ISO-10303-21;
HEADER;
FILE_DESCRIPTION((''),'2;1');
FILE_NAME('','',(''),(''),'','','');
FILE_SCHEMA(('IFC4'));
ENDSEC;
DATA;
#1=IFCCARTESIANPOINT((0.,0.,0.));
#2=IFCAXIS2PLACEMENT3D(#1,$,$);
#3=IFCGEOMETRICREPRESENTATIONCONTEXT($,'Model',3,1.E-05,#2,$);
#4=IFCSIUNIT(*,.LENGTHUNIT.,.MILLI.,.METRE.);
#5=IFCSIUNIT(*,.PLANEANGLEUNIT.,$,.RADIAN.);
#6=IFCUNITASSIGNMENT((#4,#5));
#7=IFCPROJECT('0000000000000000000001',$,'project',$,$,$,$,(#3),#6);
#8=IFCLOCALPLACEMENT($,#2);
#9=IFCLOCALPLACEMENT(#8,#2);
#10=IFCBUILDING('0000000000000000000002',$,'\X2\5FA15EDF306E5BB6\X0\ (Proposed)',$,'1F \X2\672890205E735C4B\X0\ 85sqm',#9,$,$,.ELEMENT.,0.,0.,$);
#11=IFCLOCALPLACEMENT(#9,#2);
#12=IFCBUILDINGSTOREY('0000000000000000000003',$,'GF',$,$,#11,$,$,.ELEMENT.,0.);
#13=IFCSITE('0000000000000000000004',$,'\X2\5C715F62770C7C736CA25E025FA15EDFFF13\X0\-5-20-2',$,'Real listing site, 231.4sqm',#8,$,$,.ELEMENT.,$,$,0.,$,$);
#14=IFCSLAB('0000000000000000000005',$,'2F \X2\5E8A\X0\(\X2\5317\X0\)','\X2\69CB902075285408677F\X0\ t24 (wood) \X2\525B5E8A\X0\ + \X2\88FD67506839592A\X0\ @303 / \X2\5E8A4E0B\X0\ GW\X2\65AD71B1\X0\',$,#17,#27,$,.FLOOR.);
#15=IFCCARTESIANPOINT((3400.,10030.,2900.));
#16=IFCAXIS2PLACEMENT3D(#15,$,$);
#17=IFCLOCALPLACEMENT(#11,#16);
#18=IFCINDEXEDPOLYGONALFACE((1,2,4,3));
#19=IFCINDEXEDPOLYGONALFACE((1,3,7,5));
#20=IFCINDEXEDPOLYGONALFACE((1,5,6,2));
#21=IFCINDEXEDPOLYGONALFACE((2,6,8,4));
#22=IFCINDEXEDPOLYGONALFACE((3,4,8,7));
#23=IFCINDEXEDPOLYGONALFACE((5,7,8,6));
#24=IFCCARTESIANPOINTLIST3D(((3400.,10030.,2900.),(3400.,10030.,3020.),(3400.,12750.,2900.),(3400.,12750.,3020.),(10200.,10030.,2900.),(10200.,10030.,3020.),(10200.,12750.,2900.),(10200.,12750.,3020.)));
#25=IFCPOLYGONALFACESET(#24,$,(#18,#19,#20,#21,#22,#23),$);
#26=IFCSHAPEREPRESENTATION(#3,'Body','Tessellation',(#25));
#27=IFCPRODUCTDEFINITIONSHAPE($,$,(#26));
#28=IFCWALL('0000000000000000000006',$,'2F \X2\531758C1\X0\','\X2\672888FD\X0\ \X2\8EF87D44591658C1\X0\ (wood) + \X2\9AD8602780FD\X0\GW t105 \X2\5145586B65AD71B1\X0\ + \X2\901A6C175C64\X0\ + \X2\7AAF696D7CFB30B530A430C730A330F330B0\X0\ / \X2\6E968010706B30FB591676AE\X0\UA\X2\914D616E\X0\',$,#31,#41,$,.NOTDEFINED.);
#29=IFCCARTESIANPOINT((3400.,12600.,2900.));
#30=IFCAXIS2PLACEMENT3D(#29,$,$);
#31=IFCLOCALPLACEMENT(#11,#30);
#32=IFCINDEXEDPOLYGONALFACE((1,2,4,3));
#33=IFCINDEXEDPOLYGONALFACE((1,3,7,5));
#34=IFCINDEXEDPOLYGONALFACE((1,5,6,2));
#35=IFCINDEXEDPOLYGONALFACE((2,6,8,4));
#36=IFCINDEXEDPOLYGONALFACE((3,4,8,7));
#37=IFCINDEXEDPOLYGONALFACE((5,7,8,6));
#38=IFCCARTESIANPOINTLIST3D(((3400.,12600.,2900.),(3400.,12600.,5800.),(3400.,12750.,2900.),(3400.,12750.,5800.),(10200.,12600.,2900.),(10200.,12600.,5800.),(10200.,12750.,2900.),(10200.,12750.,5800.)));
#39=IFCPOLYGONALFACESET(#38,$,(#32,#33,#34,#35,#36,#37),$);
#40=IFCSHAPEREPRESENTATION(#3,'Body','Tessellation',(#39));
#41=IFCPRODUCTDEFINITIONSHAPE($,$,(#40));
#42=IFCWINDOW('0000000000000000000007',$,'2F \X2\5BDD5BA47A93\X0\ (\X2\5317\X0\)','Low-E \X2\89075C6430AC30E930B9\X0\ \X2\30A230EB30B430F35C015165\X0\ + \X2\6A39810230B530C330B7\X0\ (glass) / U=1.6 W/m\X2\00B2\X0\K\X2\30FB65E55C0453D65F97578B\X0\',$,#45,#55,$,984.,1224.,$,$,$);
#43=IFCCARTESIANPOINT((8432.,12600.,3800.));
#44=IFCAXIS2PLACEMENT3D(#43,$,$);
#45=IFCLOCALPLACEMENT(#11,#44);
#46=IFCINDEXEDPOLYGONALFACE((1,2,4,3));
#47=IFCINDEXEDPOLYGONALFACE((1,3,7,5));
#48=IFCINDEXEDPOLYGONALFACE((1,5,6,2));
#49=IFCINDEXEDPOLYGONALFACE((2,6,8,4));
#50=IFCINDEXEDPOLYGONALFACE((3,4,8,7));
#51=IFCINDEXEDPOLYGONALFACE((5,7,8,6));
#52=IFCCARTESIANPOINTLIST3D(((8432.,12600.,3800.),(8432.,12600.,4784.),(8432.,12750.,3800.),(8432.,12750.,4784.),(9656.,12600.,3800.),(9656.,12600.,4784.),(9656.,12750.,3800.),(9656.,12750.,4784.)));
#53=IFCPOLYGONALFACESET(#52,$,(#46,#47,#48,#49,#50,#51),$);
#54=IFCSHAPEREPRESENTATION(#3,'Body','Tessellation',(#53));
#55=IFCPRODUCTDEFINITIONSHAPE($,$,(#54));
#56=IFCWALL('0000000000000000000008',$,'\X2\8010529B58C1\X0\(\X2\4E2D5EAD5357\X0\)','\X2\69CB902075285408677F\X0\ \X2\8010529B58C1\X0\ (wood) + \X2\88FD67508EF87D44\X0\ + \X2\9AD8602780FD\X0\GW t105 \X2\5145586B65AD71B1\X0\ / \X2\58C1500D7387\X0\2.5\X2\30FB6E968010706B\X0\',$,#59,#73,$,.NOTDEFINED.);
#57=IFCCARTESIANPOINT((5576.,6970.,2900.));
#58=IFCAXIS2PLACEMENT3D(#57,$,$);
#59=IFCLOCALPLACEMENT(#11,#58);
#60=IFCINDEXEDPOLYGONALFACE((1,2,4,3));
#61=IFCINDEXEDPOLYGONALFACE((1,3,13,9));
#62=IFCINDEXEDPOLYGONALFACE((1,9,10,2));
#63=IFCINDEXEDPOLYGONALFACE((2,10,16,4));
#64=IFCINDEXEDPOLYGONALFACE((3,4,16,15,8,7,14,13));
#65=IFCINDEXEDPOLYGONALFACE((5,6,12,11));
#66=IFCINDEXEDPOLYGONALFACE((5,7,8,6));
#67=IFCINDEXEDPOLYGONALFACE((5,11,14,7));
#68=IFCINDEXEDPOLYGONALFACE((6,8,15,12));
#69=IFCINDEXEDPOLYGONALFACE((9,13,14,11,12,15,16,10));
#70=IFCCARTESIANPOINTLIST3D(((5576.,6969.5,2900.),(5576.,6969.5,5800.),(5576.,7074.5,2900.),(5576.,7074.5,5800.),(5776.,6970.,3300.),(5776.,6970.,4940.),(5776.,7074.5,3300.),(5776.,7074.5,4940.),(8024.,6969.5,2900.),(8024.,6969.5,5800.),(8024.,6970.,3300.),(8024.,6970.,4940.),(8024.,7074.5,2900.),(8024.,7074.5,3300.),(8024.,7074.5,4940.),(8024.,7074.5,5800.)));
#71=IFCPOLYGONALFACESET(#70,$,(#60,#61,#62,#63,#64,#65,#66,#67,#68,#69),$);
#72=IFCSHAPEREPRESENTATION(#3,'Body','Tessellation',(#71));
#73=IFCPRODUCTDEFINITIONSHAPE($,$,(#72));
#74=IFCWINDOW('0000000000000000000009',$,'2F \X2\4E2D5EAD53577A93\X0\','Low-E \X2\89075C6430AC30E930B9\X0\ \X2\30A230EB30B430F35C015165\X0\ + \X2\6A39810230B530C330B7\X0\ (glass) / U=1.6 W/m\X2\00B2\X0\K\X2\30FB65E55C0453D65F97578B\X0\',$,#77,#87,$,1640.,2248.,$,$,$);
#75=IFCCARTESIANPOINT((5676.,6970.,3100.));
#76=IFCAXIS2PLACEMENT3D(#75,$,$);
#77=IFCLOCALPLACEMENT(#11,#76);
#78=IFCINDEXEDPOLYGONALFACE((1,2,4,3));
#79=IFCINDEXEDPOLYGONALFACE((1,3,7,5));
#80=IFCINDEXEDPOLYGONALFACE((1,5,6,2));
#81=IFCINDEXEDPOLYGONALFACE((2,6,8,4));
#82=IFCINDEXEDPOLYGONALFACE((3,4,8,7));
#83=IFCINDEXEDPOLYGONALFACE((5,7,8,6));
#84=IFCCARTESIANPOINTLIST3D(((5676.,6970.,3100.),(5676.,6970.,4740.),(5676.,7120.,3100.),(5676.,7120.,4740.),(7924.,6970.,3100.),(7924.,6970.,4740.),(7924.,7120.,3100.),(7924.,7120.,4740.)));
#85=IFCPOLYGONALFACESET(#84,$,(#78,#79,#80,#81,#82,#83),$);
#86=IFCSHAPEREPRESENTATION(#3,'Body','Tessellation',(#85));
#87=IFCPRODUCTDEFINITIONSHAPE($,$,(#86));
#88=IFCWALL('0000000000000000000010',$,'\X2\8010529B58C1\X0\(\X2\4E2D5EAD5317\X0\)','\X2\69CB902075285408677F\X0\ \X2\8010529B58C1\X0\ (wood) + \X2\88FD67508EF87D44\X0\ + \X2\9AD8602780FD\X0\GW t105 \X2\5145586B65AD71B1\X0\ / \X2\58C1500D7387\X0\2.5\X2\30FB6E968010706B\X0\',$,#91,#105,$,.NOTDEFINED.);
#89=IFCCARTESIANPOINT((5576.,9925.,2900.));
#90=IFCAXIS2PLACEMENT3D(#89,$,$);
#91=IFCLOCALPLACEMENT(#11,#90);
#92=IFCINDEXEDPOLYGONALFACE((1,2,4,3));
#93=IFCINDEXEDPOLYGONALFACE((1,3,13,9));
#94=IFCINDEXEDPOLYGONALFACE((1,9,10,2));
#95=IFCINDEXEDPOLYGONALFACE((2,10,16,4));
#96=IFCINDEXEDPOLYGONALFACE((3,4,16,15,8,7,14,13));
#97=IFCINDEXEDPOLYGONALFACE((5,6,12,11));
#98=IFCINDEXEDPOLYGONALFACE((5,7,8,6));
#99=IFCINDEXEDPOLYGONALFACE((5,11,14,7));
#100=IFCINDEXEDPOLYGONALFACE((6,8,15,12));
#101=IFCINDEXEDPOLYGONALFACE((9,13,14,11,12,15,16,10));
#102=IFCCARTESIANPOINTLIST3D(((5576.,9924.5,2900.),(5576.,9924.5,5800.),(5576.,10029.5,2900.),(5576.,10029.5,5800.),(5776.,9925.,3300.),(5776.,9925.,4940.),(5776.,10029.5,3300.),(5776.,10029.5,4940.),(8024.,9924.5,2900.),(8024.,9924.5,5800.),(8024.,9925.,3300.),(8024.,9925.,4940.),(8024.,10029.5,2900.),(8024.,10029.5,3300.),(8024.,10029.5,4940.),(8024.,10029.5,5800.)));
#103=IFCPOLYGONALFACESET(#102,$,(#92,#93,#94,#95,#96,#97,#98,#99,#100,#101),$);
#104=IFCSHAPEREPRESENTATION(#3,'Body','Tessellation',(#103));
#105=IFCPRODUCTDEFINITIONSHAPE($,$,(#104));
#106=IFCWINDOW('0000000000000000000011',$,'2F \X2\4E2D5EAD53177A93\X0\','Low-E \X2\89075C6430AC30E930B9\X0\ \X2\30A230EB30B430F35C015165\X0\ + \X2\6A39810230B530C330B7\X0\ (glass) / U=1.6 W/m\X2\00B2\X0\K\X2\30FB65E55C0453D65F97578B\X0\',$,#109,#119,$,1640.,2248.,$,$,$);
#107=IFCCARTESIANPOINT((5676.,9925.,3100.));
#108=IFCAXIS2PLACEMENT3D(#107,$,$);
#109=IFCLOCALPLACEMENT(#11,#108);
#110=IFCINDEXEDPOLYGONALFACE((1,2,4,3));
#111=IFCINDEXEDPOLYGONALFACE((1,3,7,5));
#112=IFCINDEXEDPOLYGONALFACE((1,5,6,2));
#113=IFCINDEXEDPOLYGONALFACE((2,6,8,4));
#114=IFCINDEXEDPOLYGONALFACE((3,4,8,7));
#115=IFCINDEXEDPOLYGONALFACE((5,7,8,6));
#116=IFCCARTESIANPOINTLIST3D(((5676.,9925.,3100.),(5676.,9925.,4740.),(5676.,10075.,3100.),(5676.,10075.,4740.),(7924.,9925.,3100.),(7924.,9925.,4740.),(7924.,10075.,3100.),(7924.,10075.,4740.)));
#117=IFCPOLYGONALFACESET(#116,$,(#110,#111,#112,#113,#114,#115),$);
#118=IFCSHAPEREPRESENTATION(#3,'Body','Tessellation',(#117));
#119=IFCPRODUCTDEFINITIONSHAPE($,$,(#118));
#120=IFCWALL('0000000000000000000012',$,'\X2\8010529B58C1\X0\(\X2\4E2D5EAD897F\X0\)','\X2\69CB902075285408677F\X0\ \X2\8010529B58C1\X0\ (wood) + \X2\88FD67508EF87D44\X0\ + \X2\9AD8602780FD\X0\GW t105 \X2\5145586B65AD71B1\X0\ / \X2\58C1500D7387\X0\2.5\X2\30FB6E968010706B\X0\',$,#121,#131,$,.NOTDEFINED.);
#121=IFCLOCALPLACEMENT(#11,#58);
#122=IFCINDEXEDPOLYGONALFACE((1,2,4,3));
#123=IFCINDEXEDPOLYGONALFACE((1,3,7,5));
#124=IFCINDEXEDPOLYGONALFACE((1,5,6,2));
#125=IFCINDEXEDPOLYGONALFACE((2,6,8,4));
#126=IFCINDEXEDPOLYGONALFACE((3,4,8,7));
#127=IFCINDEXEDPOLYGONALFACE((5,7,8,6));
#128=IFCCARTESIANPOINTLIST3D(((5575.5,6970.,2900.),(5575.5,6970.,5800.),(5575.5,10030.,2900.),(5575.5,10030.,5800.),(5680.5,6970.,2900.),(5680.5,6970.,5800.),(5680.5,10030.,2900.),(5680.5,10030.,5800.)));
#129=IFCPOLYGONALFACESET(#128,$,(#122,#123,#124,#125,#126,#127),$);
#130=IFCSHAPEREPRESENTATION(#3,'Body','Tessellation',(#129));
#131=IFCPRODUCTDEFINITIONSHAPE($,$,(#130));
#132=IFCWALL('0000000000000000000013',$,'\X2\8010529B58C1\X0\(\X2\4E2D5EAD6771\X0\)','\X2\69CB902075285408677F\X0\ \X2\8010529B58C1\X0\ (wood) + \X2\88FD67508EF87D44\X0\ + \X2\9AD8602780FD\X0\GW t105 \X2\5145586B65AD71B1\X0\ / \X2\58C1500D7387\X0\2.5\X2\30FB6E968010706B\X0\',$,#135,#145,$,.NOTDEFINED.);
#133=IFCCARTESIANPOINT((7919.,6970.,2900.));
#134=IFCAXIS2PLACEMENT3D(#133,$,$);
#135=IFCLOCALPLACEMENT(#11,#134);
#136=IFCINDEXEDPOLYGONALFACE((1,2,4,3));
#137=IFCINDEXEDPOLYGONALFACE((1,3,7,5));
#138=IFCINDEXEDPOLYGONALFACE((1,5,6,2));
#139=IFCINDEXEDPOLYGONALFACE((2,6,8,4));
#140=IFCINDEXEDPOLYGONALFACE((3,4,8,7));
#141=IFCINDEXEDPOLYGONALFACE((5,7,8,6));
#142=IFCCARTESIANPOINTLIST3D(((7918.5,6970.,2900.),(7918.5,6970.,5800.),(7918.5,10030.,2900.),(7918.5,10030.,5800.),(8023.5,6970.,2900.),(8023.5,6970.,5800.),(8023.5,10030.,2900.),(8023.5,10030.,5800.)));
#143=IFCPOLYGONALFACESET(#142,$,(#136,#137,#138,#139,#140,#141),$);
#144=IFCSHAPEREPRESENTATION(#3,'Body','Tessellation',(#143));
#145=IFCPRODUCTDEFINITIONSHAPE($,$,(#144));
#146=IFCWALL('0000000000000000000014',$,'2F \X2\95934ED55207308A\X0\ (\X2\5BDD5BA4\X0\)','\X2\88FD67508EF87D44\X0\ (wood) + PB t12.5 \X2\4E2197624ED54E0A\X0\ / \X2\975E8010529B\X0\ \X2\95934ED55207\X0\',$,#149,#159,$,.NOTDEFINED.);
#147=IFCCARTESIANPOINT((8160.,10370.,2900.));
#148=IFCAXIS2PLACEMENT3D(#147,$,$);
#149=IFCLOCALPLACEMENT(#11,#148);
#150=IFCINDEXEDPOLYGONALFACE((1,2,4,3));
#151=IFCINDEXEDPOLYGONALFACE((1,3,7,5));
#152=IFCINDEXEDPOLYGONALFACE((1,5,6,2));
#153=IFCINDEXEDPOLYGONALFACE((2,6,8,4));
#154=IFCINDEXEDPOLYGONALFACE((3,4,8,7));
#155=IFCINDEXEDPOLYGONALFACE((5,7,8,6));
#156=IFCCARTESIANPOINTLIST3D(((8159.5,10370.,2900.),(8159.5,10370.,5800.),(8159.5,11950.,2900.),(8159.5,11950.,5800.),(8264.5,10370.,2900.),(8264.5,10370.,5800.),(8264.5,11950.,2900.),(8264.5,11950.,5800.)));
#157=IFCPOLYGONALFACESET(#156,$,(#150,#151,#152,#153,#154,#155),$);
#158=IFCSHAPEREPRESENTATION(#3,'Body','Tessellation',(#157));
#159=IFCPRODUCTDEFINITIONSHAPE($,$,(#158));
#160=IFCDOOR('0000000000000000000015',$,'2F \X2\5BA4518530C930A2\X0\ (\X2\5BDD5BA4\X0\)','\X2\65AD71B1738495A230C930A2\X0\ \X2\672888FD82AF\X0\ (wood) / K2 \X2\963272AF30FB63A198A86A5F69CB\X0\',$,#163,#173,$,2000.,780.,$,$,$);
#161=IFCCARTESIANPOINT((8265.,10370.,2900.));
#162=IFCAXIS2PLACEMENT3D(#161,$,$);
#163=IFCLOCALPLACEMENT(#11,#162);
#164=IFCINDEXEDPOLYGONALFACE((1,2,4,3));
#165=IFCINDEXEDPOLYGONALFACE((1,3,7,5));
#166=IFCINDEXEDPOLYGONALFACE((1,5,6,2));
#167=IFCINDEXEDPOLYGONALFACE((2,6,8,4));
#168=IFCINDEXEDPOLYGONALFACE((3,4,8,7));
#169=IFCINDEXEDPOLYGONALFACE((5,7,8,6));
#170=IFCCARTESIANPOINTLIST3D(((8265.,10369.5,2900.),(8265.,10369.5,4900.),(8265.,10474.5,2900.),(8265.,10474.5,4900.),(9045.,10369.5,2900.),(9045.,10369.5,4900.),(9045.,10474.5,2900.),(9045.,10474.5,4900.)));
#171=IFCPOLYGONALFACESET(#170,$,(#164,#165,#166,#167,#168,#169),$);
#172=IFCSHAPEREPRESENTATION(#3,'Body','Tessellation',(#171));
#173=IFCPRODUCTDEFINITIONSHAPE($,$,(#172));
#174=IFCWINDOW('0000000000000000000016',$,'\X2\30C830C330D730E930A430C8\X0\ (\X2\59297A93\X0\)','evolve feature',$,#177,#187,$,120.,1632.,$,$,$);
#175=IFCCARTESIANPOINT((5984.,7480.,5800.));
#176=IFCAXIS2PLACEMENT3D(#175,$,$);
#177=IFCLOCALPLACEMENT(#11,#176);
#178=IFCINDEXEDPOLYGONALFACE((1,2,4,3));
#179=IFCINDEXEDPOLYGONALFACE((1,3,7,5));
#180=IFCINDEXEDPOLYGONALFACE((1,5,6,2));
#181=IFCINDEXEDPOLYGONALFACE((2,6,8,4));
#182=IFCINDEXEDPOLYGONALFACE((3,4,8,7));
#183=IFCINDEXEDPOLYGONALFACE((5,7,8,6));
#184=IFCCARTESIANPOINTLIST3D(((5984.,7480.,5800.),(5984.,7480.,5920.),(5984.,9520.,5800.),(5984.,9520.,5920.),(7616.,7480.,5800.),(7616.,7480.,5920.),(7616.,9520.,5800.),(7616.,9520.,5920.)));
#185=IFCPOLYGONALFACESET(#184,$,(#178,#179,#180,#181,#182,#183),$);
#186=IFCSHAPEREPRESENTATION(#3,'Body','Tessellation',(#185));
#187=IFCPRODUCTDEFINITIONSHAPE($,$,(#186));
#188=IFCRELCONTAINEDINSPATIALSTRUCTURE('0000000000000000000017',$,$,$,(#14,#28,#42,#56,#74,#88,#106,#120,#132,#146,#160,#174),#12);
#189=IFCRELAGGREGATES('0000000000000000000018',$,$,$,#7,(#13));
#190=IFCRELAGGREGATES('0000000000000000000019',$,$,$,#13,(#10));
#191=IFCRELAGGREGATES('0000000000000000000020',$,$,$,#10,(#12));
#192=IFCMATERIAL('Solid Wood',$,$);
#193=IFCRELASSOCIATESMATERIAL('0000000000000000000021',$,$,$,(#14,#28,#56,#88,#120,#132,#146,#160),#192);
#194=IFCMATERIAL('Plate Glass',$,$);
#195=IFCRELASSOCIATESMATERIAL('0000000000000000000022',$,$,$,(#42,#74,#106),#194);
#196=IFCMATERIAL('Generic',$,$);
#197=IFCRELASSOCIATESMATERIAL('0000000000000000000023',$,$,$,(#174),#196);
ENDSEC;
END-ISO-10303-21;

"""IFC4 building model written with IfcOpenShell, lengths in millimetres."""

from ifc_helpers import new_model, si_unit, frame, frame_2d, origin, place, context, project, spatial, rectangle, extrude, material, element, fill, save


model = new_model("IFC4")

# Units and contexts
model_context = context("Model", 3, precision=1e-05, world=origin())
ifc_project = project(units=[si_unit("LENGTHUNIT", "METRE", prefix="MILLI"), si_unit("PLANEANGLEUNIT", "RADIAN")], contexts=[model_context])

# Site, building, storey
site_placement = place(None, origin())
site = spatial("IfcSite", under=ifc_project, at=site_placement, Name="山形県米沢市御廟３-5-20-2", ObjectType="Real listing site, 231.4sqm", CompositionType="ELEMENT", RefElevation=0.0)
building_placement = place(site_placement, origin())
building = spatial("IfcBuilding", under=site, at=building_placement, Name="御廟の家 (Proposed)", ObjectType="1F 木造平屋 85sqm", CompositionType="ELEMENT", ElevationOfRefHeight=0.0, ElevationOfTerrain=0.0)
storey_placement = place(building_placement, origin())
storey = spatial("IfcBuildingStorey", under=building, at=storey_placement, Name="GF", CompositionType="ELEMENT", Elevation=0.0)

# Slab
ifc_material_1 = material(Name="Solid Wood")
slab_placement = place(storey_placement, frame((3400.0, 10030.0, 2900.0)))
element("IfcSlab", 1, at=slab_placement, inside=storey, material=ifc_material_1, Name="2F 床(北)", Description="構造用合板 t24 (wood) 剛床 + 製材根太 @303 / 床下 GW断熱", PredefinedType="FLOOR", context=model_context, shape_type="SweptSolid", body=[
    extrude(rectangle(XDim=6800.0, YDim=2720.0, at=frame_2d((3400.0, 1360.0))), frame((3400.0, 10030.0, 2900.0)), (0.0, 0.0, 1.0), 120.0),
])

# Walls, openings, windows
wall_1_placement = place(storey_placement, frame((3400.0, 12600.0, 2900.0)))
wall_1 = element("IfcWall", 2, at=wall_1_placement, inside=storey, material=ifc_material_1, Name="2F 北壁", Description="木製 軸組外壁 (wood) + 高性能GW t105 充填断熱 + 通気層 + 窯業系サイディング / 準耐火・外皮UA配慮", PredefinedType="NOTDEFINED", context=model_context, shape_type="SweptSolid", body=[
    extrude(rectangle(XDim=6800.0, YDim=150.0, at=frame_2d((3400.0, 75.0))), frame((3400.0, 12600.0, 2900.0)), (0.0, 0.0, 1.0), 2900.0),
])
opening_1_placement = place(storey_placement, frame((8432.0, 12600.0, 3800.0)))
opening_1 = element("IfcOpeningElement", 3, at=opening_1_placement, cuts=wall_1, PredefinedType="NOTDEFINED", context=model_context, shape_type="SweptSolid", body=[
    extrude(rectangle(XDim=1224.0, YDim=150.0, at=frame_2d((612.0, 75.0))), frame((8432.0, 12600.0, 3800.0)), (0.0, 0.0, 1.0), 984.0),
])
ifc_material_2 = material(Name="Plate Glass")
window_1_placement = place(storey_placement, frame((8432.0, 12600.0, 3800.0)))
window_1 = element("IfcWindow", 4, at=window_1_placement, inside=storey, material=ifc_material_2, Name="2F 寝室窓 (北)", Description="Low-E 複層ガラス アルゴン封入 + 樹脂サッシ (glass) / U=1.6 W/m²K・日射取得型", OverallHeight=984.0, OverallWidth=1224.0, context=model_context, shape_type="SweptSolid", body=[
    extrude(rectangle(XDim=1224.0, YDim=150.0, at=frame_2d((612.0, 75.0))), frame((8432.0, 12600.0, 3800.0)), (0.0, 0.0, 1.0), 984.0),
])
fill(opening_1, window_1)
wall_2_placement = place(storey_placement, frame((5576.0, 6970.0, 2900.0)))
wall_2 = element("IfcWall", 5, at=wall_2_placement, inside=storey, material=ifc_material_1, Name="耐力壁(中庭南)", Description="構造用合板 耐力壁 (wood) + 製材軸組 + 高性能GW t105 充填断熱 / 壁倍率2.5・準耐火", PredefinedType="NOTDEFINED", context=model_context, shape_type="SweptSolid", body=[
    extrude(rectangle(XDim=2448.0, YDim=105.0, at=frame_2d((1224.0, 52.0))), frame((5576.0, 6970.0, 2900.0)), (0.0, 0.0, 1.0), 2900.0),
])
opening_2_placement = place(storey_placement, frame((5676.0, 6970.0, 3100.0)))
opening_2 = element("IfcOpeningElement", 6, at=opening_2_placement, cuts=wall_2, PredefinedType="NOTDEFINED", context=model_context, shape_type="SweptSolid", body=[
    extrude(rectangle(XDim=2248.0, YDim=150.0, at=frame_2d((1124.0, 75.0))), frame((5676.0, 6970.0, 3100.0)), (0.0, 0.0, 1.0), 1640.0),
])
window_2_placement = place(storey_placement, frame((5676.0, 6970.0, 3100.0)))
window_2 = element("IfcWindow", 7, at=window_2_placement, inside=storey, material=ifc_material_2, Name="2F 中庭南窓", Description="Low-E 複層ガラス アルゴン封入 + 樹脂サッシ (glass) / U=1.6 W/m²K・日射取得型", OverallHeight=1640.0, OverallWidth=2248.0, context=model_context, shape_type="SweptSolid", body=[
    extrude(rectangle(XDim=2248.0, YDim=150.0, at=frame_2d((1124.0, 75.0))), frame((5676.0, 6970.0, 3100.0)), (0.0, 0.0, 1.0), 1640.0),
])
fill(opening_2, window_2)
wall_3_placement = place(storey_placement, frame((5576.0, 9925.0, 2900.0)))
wall_3 = element("IfcWall", 8, at=wall_3_placement, inside=storey, material=ifc_material_1, Name="耐力壁(中庭北)", Description="構造用合板 耐力壁 (wood) + 製材軸組 + 高性能GW t105 充填断熱 / 壁倍率2.5・準耐火", PredefinedType="NOTDEFINED", context=model_context, shape_type="SweptSolid", body=[
    extrude(rectangle(XDim=2448.0, YDim=105.0, at=frame_2d((1224.0, 52.0))), frame((5576.0, 9925.0, 2900.0)), (0.0, 0.0, 1.0), 2900.0),
])
opening_3_placement = place(storey_placement, frame((5676.0, 9925.0, 3100.0)))
opening_3 = element("IfcOpeningElement", 9, at=opening_3_placement, cuts=wall_3, PredefinedType="NOTDEFINED", context=model_context, shape_type="SweptSolid", body=[
    extrude(rectangle(XDim=2248.0, YDim=150.0, at=frame_2d((1124.0, 75.0))), frame((5676.0, 9925.0, 3100.0)), (0.0, 0.0, 1.0), 1640.0),
])
window_3_placement = place(storey_placement, frame((5676.0, 9925.0, 3100.0)))
window_3 = element("IfcWindow", 10, at=window_3_placement, inside=storey, material=ifc_material_2, Name="2F 中庭北窓", Description="Low-E 複層ガラス アルゴン封入 + 樹脂サッシ (glass) / U=1.6 W/m²K・日射取得型", OverallHeight=1640.0, OverallWidth=2248.0, context=model_context, shape_type="SweptSolid", body=[
    extrude(rectangle(XDim=2248.0, YDim=150.0, at=frame_2d((1124.0, 75.0))), frame((5676.0, 9925.0, 3100.0)), (0.0, 0.0, 1.0), 1640.0),
])
fill(opening_3, window_3)

# Walls
wall_4_placement = place(storey_placement, frame((5576.0, 6970.0, 2900.0)))
element("IfcWall", 11, at=wall_4_placement, inside=storey, material=ifc_material_1, Name="耐力壁(中庭西)", Description="構造用合板 耐力壁 (wood) + 製材軸組 + 高性能GW t105 充填断熱 / 壁倍率2.5・準耐火", PredefinedType="NOTDEFINED", context=model_context, shape_type="SweptSolid", body=[
    extrude(rectangle(XDim=105.0, YDim=3060.0, at=frame_2d((52.0, 1530.0))), frame((5576.0, 6970.0, 2900.0)), (0.0, 0.0, 1.0), 2900.0),
])
wall_5_placement = place(storey_placement, frame((7919.0, 6970.0, 2900.0)))
element("IfcWall", 12, at=wall_5_placement, inside=storey, material=ifc_material_1, Name="耐力壁(中庭東)", Description="構造用合板 耐力壁 (wood) + 製材軸組 + 高性能GW t105 充填断熱 / 壁倍率2.5・準耐火", PredefinedType="NOTDEFINED", context=model_context, shape_type="SweptSolid", body=[
    extrude(rectangle(XDim=105.0, YDim=3060.0, at=frame_2d((52.0, 1530.0))), frame((7919.0, 6970.0, 2900.0)), (0.0, 0.0, 1.0), 2900.0),
])
wall_6_placement = place(storey_placement, frame((8160.0, 10370.0, 2900.0)))
element("IfcWall", 13, at=wall_6_placement, inside=storey, material=ifc_material_1, Name="2F 間仕切り (寝室)", Description="製材軸組 (wood) + PB t12.5 両面仕上 / 非耐力 間仕切", PredefinedType="NOTDEFINED", context=model_context, shape_type="SweptSolid", body=[
    extrude(rectangle(XDim=105.0, YDim=1580.0, at=frame_2d((52.0, 790.0))), frame((8160.0, 10370.0, 2900.0)), (0.0, 0.0, 1.0), 2900.0),
])

# Door
door_placement = place(storey_placement, frame((8265.0, 10370.0, 2900.0)))
element("IfcDoor", 14, at=door_placement, inside=storey, material=ifc_material_1, Name="2F 室内ドア (寝室)", Description="断熱玄関ドア 木製芯 (wood) / K2 防犯・採風機構", OverallHeight=2000.0, OverallWidth=780.0, context=model_context, shape_type="SweptSolid", body=[
    extrude(rectangle(XDim=780.0, YDim=105.0, at=frame_2d((390.0, 52.0))), frame((8265.0, 10370.0, 2900.0)), (0.0, 0.0, 1.0), 2000.0),
])

# Window
ifc_material_3 = material(Name="Generic")
window_4_placement = place(storey_placement, frame((5984.0, 7480.0, 5800.0)))
element("IfcWindow", 15, at=window_4_placement, inside=storey, material=ifc_material_3, Name="トップライト (天窓)", Description="evolve feature", OverallHeight=120.0, OverallWidth=1632.0, context=model_context, shape_type="SweptSolid", body=[
    extrude(rectangle(XDim=1632.0, YDim=2040.0, at=frame_2d((816.0, 1020.0))), frame((5984.0, 7480.0, 5800.0)), (0.0, 0.0, 1.0), 120.0),
])

save(model, "model.ifc")
